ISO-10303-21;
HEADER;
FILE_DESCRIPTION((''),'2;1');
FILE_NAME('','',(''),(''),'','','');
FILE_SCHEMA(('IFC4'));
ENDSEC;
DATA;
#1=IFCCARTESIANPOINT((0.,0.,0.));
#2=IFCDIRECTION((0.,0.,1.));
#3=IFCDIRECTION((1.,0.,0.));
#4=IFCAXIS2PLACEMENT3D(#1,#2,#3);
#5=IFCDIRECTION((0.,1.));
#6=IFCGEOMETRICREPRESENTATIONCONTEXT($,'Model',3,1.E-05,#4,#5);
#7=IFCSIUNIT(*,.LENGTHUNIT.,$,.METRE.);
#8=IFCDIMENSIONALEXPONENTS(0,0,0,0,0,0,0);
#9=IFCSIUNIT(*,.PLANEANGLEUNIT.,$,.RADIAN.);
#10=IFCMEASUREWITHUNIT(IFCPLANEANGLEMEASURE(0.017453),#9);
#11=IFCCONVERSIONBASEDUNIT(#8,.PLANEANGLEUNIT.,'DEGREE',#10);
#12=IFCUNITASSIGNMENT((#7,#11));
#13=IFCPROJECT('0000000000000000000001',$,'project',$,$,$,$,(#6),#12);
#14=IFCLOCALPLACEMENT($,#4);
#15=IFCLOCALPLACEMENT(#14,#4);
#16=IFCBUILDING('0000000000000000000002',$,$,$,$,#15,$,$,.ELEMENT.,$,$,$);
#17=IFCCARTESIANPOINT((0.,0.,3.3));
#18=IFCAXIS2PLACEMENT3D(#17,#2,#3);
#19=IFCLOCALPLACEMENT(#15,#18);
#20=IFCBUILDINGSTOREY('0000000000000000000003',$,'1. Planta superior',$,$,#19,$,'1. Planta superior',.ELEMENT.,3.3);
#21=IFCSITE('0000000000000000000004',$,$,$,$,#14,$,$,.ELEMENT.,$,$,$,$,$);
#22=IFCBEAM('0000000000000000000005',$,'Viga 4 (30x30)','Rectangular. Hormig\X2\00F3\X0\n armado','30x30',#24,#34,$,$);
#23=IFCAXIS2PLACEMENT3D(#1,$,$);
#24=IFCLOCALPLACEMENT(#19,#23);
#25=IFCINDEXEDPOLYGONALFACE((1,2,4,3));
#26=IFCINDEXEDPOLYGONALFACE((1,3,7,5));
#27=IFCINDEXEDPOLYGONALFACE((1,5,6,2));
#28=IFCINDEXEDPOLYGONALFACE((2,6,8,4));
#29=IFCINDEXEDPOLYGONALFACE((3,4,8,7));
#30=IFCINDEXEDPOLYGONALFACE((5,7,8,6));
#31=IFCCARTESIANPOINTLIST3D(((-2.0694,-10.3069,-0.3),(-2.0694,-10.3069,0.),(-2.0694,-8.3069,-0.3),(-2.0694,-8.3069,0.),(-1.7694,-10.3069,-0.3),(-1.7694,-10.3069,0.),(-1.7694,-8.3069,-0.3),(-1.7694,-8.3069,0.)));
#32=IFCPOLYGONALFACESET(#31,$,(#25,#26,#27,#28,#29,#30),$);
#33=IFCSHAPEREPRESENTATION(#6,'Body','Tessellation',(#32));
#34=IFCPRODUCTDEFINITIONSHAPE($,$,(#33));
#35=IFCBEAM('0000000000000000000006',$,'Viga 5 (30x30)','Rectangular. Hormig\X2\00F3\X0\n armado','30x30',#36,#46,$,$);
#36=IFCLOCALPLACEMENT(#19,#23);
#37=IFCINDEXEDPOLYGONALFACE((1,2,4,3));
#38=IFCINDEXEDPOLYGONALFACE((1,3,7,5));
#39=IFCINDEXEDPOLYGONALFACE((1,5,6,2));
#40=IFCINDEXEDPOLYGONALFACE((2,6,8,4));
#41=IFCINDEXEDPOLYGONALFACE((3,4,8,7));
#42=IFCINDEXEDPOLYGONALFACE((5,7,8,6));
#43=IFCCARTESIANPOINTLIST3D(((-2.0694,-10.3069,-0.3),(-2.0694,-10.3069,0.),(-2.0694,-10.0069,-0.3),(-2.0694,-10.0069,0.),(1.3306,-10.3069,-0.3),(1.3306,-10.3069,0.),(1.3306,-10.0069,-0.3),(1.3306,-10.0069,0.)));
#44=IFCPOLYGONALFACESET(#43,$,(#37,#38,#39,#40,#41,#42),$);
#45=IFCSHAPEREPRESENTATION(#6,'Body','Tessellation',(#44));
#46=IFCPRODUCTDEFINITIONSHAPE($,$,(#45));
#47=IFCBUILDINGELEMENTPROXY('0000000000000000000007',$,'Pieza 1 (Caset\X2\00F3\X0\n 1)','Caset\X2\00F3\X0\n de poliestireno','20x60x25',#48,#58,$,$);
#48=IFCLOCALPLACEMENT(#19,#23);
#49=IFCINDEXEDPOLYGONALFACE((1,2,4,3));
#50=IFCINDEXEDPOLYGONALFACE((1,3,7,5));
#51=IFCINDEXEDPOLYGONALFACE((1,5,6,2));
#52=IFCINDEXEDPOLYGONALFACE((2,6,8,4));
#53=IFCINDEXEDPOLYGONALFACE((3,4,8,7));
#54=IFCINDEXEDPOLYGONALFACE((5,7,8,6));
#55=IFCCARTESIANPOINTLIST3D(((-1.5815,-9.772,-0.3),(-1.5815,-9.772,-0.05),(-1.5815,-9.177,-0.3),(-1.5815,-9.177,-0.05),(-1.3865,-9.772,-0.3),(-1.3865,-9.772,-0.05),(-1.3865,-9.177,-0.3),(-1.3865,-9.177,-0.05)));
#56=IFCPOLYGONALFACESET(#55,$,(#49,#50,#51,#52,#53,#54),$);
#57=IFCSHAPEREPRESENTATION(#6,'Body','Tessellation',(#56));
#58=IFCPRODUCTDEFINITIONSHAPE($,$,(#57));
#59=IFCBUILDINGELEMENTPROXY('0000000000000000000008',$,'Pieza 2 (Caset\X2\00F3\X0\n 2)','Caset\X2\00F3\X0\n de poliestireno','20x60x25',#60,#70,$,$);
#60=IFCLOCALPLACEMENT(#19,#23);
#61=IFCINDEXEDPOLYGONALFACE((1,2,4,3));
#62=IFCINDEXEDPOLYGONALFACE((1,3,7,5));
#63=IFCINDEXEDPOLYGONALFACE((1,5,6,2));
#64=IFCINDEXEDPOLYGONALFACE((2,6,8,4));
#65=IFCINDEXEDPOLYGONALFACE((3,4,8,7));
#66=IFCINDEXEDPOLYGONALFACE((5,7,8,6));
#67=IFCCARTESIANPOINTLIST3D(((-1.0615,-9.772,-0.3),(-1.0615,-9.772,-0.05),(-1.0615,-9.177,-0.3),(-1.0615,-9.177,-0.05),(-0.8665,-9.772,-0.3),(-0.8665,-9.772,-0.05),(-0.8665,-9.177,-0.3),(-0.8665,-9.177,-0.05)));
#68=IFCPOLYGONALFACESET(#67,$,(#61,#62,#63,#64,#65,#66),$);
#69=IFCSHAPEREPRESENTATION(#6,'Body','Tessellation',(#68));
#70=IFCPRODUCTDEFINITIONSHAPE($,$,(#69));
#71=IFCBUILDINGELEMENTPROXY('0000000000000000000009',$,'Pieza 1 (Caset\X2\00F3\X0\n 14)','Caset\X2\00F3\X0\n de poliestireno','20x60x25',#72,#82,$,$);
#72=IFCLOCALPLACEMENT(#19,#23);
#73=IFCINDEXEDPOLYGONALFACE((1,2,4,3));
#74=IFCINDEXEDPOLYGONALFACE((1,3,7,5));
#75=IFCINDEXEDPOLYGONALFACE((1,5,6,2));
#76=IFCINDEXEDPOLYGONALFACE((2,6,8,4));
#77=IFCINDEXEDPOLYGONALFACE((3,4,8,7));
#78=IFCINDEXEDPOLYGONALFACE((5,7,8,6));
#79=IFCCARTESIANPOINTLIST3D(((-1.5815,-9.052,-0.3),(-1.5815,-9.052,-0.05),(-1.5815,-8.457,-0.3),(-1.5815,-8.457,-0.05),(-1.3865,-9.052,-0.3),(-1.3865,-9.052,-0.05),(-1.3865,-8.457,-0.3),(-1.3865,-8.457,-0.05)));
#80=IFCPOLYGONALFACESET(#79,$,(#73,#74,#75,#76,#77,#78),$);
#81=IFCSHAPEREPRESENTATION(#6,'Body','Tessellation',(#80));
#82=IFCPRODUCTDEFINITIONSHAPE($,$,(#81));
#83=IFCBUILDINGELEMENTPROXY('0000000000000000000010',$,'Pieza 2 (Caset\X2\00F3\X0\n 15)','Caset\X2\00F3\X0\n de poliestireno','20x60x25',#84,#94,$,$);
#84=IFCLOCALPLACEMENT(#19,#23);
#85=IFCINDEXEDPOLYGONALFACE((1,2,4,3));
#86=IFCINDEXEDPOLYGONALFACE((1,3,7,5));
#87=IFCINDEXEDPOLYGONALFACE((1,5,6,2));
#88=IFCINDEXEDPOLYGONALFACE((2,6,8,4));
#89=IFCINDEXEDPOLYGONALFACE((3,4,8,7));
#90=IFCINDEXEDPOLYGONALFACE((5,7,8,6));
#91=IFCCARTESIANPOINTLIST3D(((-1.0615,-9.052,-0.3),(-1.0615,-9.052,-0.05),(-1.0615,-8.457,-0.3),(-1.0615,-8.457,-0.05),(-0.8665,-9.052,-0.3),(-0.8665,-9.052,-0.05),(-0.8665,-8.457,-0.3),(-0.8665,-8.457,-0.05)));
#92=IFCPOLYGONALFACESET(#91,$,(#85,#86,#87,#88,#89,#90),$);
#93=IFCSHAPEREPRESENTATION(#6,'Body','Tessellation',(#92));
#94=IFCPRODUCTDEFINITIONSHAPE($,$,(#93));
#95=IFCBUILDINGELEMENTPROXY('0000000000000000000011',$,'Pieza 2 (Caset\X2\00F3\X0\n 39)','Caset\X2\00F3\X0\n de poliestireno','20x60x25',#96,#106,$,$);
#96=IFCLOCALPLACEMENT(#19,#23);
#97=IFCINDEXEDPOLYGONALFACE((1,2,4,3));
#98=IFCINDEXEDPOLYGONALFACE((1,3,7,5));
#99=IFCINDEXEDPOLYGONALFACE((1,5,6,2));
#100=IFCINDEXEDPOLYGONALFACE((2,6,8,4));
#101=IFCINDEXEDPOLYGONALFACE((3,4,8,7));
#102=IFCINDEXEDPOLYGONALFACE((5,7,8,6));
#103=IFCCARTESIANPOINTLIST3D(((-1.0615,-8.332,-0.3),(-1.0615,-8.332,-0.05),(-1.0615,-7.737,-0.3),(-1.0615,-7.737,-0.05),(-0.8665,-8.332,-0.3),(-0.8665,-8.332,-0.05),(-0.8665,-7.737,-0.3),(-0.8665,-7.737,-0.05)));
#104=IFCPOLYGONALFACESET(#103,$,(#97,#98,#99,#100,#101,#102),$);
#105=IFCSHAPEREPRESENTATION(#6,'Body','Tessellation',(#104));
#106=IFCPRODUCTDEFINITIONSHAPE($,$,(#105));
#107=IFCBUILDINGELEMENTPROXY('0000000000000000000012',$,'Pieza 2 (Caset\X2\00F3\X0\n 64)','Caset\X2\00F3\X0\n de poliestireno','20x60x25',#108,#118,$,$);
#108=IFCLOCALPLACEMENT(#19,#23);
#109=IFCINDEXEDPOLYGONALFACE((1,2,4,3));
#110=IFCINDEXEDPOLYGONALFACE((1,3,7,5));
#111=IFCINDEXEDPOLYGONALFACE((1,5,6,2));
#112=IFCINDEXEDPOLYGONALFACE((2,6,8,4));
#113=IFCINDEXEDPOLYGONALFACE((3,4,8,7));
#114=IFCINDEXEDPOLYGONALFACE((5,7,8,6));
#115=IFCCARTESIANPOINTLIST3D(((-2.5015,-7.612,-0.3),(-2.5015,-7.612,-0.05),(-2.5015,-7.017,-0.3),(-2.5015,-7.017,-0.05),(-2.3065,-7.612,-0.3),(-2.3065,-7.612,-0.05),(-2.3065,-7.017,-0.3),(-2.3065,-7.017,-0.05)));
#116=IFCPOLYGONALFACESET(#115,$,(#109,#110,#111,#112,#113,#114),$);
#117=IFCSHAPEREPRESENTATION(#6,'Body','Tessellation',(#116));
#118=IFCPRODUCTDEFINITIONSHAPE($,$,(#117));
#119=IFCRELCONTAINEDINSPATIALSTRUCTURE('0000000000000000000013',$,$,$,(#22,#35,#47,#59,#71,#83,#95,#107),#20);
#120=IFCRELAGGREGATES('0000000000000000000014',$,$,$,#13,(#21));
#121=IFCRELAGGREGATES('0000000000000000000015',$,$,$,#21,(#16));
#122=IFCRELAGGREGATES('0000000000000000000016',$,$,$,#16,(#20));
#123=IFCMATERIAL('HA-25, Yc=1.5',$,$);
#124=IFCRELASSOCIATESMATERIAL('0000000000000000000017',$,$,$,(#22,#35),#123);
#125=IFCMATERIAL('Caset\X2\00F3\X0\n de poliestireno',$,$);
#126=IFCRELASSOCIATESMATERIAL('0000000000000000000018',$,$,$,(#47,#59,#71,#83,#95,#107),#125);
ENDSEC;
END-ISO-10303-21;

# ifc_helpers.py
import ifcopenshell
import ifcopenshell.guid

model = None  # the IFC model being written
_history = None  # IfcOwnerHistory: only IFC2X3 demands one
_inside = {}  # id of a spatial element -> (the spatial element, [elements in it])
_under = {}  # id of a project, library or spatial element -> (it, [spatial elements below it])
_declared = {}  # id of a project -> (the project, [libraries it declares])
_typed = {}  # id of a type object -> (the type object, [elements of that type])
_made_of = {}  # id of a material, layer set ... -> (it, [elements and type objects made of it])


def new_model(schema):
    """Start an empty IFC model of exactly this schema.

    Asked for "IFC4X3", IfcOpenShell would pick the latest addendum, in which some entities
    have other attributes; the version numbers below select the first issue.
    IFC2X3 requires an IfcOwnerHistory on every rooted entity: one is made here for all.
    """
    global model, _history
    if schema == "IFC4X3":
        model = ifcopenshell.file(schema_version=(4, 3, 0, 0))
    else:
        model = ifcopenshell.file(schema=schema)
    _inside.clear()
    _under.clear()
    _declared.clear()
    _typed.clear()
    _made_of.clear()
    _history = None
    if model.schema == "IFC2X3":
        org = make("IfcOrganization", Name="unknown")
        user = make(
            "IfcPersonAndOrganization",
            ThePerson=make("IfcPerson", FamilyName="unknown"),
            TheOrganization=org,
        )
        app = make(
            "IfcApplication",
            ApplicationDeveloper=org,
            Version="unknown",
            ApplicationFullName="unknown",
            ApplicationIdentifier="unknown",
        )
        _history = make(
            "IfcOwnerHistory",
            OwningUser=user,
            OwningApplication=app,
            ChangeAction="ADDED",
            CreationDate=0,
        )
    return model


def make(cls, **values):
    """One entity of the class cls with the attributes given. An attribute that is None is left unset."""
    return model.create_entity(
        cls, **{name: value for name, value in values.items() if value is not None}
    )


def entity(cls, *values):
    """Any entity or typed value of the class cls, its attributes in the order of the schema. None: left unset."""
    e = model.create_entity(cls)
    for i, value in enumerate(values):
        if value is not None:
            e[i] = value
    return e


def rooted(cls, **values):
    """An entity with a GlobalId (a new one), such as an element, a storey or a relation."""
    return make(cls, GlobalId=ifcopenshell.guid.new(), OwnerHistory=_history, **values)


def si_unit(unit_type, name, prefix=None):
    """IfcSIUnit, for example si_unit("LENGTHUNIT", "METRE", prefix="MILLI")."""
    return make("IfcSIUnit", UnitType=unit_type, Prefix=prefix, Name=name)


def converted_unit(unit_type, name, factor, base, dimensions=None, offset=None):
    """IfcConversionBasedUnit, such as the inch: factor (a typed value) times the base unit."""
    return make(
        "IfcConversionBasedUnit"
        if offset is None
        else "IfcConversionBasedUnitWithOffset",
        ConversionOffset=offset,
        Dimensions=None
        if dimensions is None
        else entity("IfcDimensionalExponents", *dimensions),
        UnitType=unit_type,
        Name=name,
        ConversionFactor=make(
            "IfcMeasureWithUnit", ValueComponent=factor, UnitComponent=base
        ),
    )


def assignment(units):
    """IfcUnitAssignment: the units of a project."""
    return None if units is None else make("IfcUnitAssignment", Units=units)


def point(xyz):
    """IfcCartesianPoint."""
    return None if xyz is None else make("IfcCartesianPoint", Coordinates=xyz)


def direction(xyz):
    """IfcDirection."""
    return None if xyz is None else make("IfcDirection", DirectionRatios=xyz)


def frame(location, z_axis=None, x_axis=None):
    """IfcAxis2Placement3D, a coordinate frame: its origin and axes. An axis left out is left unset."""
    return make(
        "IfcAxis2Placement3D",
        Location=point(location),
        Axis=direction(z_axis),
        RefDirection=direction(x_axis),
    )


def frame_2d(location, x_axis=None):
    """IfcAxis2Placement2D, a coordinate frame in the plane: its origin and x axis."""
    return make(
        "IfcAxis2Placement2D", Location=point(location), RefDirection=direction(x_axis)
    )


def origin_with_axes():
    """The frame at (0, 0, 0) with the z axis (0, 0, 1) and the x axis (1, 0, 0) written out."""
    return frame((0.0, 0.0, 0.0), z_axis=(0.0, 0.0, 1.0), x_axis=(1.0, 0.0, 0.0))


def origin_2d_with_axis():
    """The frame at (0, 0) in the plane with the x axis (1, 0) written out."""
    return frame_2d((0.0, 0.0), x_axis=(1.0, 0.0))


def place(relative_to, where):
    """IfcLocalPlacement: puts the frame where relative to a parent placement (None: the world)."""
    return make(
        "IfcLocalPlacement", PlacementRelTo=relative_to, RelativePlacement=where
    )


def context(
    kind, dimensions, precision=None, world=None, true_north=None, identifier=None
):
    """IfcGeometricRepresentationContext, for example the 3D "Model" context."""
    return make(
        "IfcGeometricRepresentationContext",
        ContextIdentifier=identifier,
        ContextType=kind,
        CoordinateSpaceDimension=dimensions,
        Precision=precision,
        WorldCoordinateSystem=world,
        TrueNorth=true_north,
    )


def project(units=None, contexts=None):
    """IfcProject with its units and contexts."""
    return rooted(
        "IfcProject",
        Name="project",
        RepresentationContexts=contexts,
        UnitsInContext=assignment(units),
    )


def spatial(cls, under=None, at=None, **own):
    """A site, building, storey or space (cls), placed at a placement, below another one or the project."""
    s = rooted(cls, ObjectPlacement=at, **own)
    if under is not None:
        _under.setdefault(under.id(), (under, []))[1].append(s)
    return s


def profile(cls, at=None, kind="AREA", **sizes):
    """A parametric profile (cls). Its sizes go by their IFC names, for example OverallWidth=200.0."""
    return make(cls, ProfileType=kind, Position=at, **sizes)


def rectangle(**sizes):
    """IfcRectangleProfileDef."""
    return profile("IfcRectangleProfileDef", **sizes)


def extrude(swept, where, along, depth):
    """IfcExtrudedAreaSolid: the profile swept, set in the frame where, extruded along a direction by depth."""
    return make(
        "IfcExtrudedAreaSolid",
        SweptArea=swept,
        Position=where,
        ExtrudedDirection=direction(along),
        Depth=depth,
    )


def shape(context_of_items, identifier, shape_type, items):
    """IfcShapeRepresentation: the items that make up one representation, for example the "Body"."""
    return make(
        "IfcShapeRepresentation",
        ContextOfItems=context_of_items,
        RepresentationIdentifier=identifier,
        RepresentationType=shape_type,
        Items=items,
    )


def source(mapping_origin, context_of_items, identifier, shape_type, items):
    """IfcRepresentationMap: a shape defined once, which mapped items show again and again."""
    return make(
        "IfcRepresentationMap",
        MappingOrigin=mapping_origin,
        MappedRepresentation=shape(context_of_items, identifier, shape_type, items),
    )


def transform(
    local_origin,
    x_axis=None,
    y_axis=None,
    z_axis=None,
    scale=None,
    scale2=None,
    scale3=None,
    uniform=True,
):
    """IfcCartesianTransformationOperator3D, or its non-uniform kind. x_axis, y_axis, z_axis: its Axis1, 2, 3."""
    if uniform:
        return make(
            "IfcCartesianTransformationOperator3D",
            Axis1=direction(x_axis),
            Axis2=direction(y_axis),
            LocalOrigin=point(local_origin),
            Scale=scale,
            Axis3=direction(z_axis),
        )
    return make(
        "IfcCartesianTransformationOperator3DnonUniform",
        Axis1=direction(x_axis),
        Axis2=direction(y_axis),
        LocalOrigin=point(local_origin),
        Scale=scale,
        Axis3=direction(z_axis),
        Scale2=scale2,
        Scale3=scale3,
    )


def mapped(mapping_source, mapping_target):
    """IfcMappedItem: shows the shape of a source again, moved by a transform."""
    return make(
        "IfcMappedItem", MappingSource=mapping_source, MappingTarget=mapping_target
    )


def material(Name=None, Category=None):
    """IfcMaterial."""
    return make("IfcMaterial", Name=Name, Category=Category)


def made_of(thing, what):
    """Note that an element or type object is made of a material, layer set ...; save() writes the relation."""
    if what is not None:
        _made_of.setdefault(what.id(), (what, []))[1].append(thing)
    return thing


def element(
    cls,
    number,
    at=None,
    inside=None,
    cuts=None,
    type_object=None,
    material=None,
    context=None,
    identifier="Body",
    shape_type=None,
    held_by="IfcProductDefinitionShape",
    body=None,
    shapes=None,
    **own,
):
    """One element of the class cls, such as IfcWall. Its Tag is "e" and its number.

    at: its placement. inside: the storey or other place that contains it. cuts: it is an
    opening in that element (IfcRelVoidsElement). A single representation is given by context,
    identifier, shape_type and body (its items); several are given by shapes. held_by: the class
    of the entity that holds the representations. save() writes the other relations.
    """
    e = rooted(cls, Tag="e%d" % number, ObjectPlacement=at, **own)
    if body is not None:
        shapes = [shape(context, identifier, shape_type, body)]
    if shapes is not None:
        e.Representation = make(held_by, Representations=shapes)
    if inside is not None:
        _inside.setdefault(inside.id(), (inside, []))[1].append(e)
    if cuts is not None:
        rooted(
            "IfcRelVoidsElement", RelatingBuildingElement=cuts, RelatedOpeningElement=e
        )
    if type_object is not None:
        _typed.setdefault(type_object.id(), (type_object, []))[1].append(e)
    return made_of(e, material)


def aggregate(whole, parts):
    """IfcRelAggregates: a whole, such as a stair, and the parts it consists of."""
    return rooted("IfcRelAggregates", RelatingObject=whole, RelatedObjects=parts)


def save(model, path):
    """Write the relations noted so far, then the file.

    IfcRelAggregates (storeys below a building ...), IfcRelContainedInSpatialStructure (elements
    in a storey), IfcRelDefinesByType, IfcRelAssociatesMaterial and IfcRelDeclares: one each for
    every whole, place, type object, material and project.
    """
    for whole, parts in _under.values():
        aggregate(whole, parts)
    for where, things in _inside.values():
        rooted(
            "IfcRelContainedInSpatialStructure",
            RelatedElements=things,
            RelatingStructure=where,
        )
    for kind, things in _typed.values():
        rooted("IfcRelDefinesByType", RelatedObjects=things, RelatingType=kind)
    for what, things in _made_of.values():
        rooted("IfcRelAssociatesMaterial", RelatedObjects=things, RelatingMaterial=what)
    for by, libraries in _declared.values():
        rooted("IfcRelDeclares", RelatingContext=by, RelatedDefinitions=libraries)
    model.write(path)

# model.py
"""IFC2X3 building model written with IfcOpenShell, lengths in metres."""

from ifc_helpers import new_model, entity, si_unit, converted_unit, direction, frame, frame_2d, origin_with_axes, origin_2d_with_axis, place, context, project, spatial, rectangle, extrude, source, transform, mapped, material, element, save


model = new_model("IFC2X3")

# Units and contexts
model_context = context("Model", 3, precision=1e-05, world=origin_with_axes(), true_north=direction((0.0, 1.0)))
ifc_project = project(units=[si_unit("LENGTHUNIT", "METRE"), converted_unit("PLANEANGLEUNIT", "DEGREE", entity("IfcPlaneAngleMeasure", 0.017453), si_unit("PLANEANGLEUNIT", "RADIAN"), dimensions=[0, 0, 0, 0, 0, 0, 0])], contexts=[model_context])

# Site, building, storey
site_placement = place(None, origin_with_axes())
site = spatial("IfcSite", under=ifc_project, at=site_placement, CompositionType="ELEMENT")
building_placement = place(site_placement, origin_with_axes())
building = spatial("IfcBuilding", under=site, at=building_placement, CompositionType="ELEMENT")
storey_placement = place(building_placement, frame((0.0, 0.0, 3.3), z_axis=(0.0, 0.0, 1.0), x_axis=(1.0, 0.0, 0.0)))
storey = spatial("IfcBuildingStorey", under=building, at=storey_placement, Name="1. Planta superior", LongName="1. Planta superior", CompositionType="ELEMENT", Elevation=3.3)

# Beams
ifc_material_1 = material(Name="HA-25, Yc=1.5")
beam_1_placement = place(storey_placement, frame((-1.9194, -10.3069, 0.0), z_axis=(0.0, 1.0, 0.0), x_axis=(-1.0, 0.0, 0.0)))
element("IfcBeam", 1, at=beam_1_placement, inside=storey, material=ifc_material_1, Name="Viga 4 (30x30)", Description="Rectangular. Hormigón armado", ObjectType="30x30", context=model_context, shape_type="SweptSolid", body=[
    extrude(rectangle(XDim=0.3, YDim=0.3, at=frame_2d((0.0, -0.15), x_axis=(1.0, 0.0))), origin_with_axes(), (0.0, 0.0, 1.0), 2.0),
])
beam_2_placement = place(storey_placement, frame((-2.0694, -10.1569, 0.0), z_axis=(1.0, 0.0, 0.0), x_axis=(0.0, 1.0, 0.0)))
element("IfcBeam", 2, at=beam_2_placement, inside=storey, material=ifc_material_1, Name="Viga 5 (30x30)", Description="Rectangular. Hormigón armado", ObjectType="30x30", context=model_context, shape_type="SweptSolid", body=[
    extrude(rectangle(XDim=0.3, YDim=0.3, at=frame_2d((0.0, -0.15), x_axis=(1.0, 0.0))), origin_with_axes(), (0.0, 0.0, 1.0), 3.4),
])

# Building element proxies
ifc_material_2 = material(Name="Casetón de poliestireno")
shared_shape = source(origin_with_axes(), model_context, "Body", "SweptSolid", [
    extrude(rectangle(XDim=0.195, YDim=0.25, at=origin_2d_with_axis()), origin_with_axes(), (0.0, 0.0, 1.0), 0.595),
])
placement_1 = place(storey_placement, frame((-1.484, -9.772, -0.175), z_axis=(0.0, 1.0, 0.0), x_axis=(-1.0, 0.0, 0.0)))
proxy_1_placement = place(placement_1, origin_with_axes())
element("IfcBuildingElementProxy", 3, at=proxy_1_placement, inside=storey, material=ifc_material_2, Name="Pieza 1 (Casetón 1)", Description="Casetón de poliestireno", ObjectType="20x60x25", context=model_context, shape_type="MappedRepresentation", body=[
    mapped(shared_shape, transform((0.0, 0.0, 0.0), x_axis=(1.0, 0.0, 0.0), y_axis=(0.0, 1.0, 0.0), z_axis=(0.0, 0.0, 1.0))),
])
placement_2 = place(storey_placement, frame((-0.964, -9.772, -0.175), z_axis=(0.0, 1.0, 0.0), x_axis=(-1.0, 0.0, 0.0)))
for number, where, z_axis, x_axis, name in (
    (4, (0.0, 0.0, 0.0), (0.0, 0.0, 1.0), (1.0, 0.0, 0.0), "Pieza 2 (Casetón 2)"),
):
    element("IfcBuildingElementProxy", number, at=place(placement_2, frame(where, z_axis=z_axis, x_axis=x_axis)), inside=storey, material=ifc_material_2, Name=name, Description="Casetón de poliestireno", ObjectType="20x60x25", context=model_context, shape_type="MappedRepresentation", body=[
        mapped(shared_shape, transform((0.0, 0.0, 0.0), x_axis=(1.0, 0.0, 0.0), y_axis=(0.0, 1.0, 0.0), z_axis=(0.0, 0.0, 1.0))),
    ])
placement_3 = place(storey_placement, frame((-1.484, -9.052, -0.175), z_axis=(0.0, 1.0, 0.0), x_axis=(-1.0, 0.0, 0.0)))
proxy_2_placement = place(placement_3, origin_with_axes())
element("IfcBuildingElementProxy", 5, at=proxy_2_placement, inside=storey, material=ifc_material_2, Name="Pieza 1 (Casetón 14)", Description="Casetón de poliestireno", ObjectType="20x60x25", context=model_context, shape_type="MappedRepresentation", body=[
    mapped(shared_shape, transform((0.0, 0.0, 0.0), x_axis=(1.0, 0.0, 0.0), y_axis=(0.0, 1.0, 0.0), z_axis=(0.0, 0.0, 1.0))),
])
placement_4 = place(storey_placement, frame((-0.964, -9.052, -0.175), z_axis=(0.0, 1.0, 0.0), x_axis=(-1.0, 0.0, 0.0)))
for number, where, z_axis, x_axis, name in (
    (6, (0.0, 0.0, 0.0), (0.0, 0.0, 1.0), (1.0, 0.0, 0.0), "Pieza 2 (Casetón 15)"),
):
    element("IfcBuildingElementProxy", number, at=place(placement_4, frame(where, z_axis=z_axis, x_axis=x_axis)), inside=storey, material=ifc_material_2, Name=name, Description="Casetón de poliestireno", ObjectType="20x60x25", context=model_context, shape_type="MappedRepresentation", body=[
        mapped(shared_shape, transform((0.0, 0.0, 0.0), x_axis=(1.0, 0.0, 0.0), y_axis=(0.0, 1.0, 0.0), z_axis=(0.0, 0.0, 1.0))),
    ])
placement_5 = place(storey_placement, frame((-0.964, -8.332, -0.175), z_axis=(0.0, 1.0, 0.0), x_axis=(-1.0, 0.0, 0.0)))
for number, where, z_axis, x_axis, name in (
    (7, (0.0, 0.0, 0.0), (0.0, 0.0, 1.0), (1.0, 0.0, 0.0), "Pieza 2 (Casetón 39)"),
):
    element("IfcBuildingElementProxy", number, at=place(placement_5, frame(where, z_axis=z_axis, x_axis=x_axis)), inside=storey, material=ifc_material_2, Name=name, Description="Casetón de poliestireno", ObjectType="20x60x25", context=model_context, shape_type="MappedRepresentation", body=[
        mapped(shared_shape, transform((0.0, 0.0, 0.0), x_axis=(1.0, 0.0, 0.0), y_axis=(0.0, 1.0, 0.0), z_axis=(0.0, 0.0, 1.0))),
    ])
placement_6 = place(storey_placement, frame((-2.404, -7.612, -0.175), z_axis=(0.0, 1.0, 0.0), x_axis=(-1.0, 0.0, 0.0)))
for number, where, z_axis, x_axis, name in (
    (8, (0.0, 0.0, 0.0), (0.0, 0.0, 1.0), (1.0, 0.0, 0.0), "Pieza 2 (Casetón 64)"),
):
    element("IfcBuildingElementProxy", number, at=place(placement_6, frame(where, z_axis=z_axis, x_axis=x_axis)), inside=storey, material=ifc_material_2, Name=name, Description="Casetón de poliestireno", ObjectType="20x60x25", context=model_context, shape_type="MappedRepresentation", body=[
        mapped(shared_shape, transform((0.0, 0.0, 0.0), x_axis=(1.0, 0.0, 0.0), y_axis=(0.0, 1.0, 0.0), z_axis=(0.0, 0.0, 1.0))),
    ])

save(model, "model.ifc")
